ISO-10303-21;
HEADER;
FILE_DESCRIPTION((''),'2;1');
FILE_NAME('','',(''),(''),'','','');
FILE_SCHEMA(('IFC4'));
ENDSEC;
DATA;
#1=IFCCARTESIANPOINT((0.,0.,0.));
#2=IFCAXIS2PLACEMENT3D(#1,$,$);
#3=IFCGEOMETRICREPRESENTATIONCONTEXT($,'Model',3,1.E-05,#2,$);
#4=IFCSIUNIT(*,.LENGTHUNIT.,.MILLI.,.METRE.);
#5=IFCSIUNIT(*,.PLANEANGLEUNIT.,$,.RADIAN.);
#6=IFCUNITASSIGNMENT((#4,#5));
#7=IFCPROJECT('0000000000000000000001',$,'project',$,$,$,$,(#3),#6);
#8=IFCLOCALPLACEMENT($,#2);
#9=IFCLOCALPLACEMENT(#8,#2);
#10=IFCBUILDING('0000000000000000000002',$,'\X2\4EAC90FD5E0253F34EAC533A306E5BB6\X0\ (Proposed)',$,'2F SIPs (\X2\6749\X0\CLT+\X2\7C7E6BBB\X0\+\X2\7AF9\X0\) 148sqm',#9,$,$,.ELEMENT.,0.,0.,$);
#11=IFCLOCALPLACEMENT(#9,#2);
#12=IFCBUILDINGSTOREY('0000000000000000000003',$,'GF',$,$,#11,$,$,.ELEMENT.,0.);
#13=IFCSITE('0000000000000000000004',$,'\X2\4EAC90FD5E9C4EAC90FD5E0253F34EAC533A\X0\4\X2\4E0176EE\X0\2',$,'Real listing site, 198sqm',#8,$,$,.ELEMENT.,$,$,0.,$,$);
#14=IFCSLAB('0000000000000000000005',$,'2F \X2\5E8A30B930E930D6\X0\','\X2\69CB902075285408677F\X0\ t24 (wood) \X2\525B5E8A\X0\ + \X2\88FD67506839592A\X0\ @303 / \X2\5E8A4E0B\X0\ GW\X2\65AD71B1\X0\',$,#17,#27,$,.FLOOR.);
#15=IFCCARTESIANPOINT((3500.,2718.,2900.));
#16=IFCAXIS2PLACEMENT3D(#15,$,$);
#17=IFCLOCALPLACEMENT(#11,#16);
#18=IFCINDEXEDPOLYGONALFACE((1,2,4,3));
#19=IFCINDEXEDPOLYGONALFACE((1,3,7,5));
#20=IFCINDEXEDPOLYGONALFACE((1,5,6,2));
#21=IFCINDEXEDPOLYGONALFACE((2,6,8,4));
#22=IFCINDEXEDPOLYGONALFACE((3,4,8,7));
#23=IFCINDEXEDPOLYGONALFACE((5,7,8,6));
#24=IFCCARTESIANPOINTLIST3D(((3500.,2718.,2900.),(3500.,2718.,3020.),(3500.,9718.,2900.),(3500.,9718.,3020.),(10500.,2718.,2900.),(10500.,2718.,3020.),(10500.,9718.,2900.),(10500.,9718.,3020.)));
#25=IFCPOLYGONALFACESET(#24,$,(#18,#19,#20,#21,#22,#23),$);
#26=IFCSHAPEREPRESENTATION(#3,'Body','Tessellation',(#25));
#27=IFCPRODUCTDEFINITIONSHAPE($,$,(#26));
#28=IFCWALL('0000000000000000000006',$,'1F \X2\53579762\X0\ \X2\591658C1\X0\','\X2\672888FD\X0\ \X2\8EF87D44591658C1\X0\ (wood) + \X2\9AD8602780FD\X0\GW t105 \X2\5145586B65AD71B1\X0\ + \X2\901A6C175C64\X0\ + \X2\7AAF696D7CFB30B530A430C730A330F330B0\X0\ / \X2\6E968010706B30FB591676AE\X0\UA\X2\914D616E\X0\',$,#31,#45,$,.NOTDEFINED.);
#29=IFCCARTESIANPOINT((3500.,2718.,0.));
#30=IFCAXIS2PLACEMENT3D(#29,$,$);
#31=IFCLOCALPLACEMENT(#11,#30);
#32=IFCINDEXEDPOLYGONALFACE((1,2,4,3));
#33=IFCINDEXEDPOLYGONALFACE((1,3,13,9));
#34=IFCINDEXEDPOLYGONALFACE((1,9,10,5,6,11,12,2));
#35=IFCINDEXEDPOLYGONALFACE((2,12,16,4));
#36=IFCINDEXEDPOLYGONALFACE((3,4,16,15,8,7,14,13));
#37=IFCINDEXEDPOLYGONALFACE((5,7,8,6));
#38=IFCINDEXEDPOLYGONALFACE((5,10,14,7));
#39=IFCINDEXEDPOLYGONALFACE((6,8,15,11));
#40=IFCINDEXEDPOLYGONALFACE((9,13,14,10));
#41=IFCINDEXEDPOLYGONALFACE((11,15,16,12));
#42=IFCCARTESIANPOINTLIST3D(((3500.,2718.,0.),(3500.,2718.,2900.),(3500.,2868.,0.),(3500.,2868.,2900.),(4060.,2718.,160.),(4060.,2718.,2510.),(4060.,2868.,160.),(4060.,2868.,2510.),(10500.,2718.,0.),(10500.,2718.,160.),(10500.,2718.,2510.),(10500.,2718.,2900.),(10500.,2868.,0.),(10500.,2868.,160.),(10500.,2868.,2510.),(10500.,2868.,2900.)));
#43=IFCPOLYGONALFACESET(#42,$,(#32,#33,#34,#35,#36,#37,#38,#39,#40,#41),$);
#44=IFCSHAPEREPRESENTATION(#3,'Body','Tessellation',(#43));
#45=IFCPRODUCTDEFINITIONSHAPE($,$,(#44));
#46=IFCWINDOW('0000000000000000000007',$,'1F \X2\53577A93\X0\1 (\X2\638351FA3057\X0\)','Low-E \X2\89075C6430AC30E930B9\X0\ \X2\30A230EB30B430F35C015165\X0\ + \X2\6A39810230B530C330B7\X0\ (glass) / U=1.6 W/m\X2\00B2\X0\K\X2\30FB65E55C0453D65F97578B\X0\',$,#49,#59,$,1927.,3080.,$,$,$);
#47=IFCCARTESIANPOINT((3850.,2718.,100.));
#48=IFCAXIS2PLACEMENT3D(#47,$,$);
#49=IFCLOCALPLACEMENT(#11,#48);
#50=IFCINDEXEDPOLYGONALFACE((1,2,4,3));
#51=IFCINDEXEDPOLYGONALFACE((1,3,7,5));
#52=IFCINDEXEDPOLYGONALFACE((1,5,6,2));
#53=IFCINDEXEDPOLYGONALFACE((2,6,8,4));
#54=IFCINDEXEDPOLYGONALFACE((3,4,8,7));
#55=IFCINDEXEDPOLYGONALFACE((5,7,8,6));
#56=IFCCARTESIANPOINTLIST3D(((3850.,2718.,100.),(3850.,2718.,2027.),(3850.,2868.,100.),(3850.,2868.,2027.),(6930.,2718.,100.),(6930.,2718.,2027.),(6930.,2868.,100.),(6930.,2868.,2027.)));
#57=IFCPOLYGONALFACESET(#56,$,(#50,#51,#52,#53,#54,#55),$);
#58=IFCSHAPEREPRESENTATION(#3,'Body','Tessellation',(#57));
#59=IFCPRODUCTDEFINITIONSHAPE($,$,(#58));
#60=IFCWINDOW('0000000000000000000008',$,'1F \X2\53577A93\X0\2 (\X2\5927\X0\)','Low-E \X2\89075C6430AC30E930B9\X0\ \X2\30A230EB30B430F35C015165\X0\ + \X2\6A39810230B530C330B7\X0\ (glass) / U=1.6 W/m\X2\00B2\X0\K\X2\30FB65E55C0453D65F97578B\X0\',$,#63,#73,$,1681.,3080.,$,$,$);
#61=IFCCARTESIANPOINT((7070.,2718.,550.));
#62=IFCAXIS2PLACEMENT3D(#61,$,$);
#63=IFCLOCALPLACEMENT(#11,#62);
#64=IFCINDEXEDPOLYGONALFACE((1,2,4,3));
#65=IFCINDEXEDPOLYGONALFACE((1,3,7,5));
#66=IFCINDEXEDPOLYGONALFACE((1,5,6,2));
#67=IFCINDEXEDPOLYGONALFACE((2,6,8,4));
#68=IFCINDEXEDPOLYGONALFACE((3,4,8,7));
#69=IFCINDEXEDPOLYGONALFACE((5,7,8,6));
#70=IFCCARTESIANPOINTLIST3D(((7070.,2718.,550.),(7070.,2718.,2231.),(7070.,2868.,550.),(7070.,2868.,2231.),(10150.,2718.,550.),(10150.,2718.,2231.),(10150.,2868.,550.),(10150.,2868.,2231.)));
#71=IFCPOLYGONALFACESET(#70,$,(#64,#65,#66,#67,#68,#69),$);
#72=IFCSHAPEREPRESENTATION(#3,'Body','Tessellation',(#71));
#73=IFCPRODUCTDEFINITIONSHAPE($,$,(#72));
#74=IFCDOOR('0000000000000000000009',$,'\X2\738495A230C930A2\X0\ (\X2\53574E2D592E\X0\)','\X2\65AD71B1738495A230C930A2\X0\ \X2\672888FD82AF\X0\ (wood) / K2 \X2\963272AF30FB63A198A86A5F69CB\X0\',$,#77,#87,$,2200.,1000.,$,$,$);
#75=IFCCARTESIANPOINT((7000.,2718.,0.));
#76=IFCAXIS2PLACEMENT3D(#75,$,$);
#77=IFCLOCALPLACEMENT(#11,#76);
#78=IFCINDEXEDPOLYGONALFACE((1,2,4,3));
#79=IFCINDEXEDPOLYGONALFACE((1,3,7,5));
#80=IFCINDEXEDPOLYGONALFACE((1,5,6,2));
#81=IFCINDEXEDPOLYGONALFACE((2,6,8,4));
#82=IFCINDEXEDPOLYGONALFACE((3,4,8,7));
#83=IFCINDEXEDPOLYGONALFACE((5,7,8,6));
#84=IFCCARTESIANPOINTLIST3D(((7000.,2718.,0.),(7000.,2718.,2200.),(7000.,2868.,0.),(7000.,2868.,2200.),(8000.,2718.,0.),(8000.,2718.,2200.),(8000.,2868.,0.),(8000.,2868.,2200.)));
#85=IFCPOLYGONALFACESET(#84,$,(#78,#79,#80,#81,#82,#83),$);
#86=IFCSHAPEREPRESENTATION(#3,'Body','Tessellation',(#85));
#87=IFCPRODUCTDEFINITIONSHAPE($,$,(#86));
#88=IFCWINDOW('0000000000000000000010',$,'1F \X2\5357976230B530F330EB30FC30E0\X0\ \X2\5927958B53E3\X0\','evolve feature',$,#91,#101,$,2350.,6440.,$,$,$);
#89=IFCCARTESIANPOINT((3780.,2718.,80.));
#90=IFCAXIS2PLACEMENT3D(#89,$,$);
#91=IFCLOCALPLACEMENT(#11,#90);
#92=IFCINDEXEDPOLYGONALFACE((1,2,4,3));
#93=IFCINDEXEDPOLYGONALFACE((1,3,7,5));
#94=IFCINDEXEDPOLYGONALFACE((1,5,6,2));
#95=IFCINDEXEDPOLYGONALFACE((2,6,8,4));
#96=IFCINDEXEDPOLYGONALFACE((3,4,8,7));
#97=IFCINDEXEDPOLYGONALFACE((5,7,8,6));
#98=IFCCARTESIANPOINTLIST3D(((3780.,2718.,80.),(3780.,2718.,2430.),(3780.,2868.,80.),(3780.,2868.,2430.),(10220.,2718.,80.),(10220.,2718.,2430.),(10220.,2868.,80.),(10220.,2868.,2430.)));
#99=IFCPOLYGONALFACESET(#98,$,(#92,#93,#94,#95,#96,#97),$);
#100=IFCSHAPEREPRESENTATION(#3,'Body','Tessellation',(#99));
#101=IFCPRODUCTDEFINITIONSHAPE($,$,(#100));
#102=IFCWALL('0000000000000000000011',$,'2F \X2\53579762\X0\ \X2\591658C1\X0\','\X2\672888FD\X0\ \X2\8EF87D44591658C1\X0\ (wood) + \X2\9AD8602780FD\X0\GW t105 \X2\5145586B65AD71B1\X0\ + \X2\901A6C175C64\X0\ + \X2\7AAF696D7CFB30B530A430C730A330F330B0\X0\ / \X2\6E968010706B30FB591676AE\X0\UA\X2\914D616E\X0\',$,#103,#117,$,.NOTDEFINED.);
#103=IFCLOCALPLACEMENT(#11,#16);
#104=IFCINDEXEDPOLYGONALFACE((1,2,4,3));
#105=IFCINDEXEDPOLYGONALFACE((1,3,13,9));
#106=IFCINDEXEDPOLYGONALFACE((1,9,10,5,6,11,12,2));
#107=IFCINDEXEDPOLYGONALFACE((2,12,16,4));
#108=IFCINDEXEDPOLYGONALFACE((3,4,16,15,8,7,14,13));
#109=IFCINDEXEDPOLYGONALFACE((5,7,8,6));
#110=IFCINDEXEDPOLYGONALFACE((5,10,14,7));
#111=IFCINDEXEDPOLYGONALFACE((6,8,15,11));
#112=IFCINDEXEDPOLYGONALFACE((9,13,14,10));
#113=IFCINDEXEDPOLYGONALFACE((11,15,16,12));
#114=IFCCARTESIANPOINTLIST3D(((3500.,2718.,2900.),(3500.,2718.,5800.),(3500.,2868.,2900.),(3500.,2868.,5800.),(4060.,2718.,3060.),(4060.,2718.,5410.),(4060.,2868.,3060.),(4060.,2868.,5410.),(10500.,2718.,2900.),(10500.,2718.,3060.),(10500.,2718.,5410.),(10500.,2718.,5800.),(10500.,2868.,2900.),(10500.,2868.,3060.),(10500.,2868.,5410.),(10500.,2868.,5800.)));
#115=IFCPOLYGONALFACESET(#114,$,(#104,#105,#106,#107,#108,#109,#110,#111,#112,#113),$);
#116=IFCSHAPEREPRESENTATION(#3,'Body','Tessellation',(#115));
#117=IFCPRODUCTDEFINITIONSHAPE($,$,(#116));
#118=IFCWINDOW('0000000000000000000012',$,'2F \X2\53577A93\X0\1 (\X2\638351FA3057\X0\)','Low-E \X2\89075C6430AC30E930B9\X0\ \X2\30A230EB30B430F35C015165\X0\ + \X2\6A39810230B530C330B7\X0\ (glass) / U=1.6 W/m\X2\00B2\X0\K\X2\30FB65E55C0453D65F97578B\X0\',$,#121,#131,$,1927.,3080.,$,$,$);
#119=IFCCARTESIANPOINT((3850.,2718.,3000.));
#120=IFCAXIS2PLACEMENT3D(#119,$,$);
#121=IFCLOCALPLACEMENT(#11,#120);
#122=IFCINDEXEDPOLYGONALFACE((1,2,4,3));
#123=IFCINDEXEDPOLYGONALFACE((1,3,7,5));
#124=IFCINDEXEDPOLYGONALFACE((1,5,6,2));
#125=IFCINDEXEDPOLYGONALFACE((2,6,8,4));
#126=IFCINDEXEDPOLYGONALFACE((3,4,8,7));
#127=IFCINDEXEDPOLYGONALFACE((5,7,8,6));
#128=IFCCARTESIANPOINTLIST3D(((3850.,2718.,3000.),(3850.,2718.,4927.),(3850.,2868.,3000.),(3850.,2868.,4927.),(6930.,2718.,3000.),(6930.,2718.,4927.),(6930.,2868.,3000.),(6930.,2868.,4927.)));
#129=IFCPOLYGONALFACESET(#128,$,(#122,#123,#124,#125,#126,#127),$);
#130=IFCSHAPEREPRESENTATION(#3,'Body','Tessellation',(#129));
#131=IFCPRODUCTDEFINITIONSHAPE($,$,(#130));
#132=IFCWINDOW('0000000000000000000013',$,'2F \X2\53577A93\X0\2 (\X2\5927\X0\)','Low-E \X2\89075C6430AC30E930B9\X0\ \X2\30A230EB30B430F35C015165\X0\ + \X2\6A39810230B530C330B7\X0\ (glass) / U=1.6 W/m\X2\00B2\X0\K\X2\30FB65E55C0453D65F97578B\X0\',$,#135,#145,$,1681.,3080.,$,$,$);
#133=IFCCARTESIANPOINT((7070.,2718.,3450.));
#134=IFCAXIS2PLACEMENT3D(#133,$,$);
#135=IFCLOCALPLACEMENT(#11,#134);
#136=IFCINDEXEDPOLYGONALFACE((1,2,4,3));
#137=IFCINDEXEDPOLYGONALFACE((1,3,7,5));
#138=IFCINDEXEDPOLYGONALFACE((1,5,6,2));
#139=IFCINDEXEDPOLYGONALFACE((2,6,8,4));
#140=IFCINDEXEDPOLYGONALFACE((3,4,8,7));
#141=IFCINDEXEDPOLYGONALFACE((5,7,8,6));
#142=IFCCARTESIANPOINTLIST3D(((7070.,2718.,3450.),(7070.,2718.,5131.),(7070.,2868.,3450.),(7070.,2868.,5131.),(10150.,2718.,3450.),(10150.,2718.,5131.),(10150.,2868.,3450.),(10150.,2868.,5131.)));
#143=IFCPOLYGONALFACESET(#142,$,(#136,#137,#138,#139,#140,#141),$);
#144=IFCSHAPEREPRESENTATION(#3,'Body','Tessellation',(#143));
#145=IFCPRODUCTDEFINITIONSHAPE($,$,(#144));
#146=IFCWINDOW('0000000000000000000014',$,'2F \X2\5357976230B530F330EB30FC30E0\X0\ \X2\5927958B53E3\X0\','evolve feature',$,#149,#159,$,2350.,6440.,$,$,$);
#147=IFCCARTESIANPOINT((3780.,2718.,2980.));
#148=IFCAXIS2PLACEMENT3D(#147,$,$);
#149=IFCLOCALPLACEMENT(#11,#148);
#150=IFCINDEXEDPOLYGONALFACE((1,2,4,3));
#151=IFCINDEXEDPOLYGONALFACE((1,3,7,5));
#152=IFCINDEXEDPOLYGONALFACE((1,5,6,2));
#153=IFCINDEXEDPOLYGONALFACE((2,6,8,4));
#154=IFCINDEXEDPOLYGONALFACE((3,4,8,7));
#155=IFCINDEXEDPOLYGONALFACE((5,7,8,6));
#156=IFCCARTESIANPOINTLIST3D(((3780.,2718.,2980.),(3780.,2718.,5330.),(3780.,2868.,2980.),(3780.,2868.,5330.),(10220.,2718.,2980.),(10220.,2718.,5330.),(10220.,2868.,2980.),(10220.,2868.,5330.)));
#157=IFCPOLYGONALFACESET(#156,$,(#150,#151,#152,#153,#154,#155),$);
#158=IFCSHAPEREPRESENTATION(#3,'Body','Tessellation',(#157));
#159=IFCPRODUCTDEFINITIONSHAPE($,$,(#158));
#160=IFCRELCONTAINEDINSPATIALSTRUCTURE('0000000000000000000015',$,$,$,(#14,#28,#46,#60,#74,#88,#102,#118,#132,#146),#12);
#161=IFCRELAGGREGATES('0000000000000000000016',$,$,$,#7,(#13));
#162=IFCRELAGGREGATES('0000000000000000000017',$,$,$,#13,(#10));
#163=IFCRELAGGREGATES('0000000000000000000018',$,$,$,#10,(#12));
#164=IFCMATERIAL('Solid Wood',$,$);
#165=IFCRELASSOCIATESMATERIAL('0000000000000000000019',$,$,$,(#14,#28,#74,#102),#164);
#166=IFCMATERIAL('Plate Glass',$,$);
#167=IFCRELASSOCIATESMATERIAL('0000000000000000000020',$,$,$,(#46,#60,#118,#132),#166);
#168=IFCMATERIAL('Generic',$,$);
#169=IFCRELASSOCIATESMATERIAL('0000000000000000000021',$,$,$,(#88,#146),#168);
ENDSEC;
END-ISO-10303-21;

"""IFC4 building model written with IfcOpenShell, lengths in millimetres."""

from ifc_helpers import new_model, si_unit, frame, frame_2d, origin, place, context, project, spatial, rectangle, extrude, material, element, fill, save


model = new_model("IFC4")

# Units and contexts
model_context = context("Model", 3, precision=1e-05, world=origin())
ifc_project = project(units=[si_unit("LENGTHUNIT", "METRE", prefix="MILLI"), si_unit("PLANEANGLEUNIT", "RADIAN")], contexts=[model_context])

# Site, building, storey
site_placement = place(None, origin())
site = spatial("IfcSite", under=ifc_project, at=site_placement, Name="京都府京都市右京区4丁目2", ObjectType="Real listing site, 198sqm", CompositionType="ELEMENT", RefElevation=0.0)
building_placement = place(site_placement, origin())
building = spatial("IfcBuilding", under=site, at=building_placement, Name="京都市右京区の家 (Proposed)", ObjectType="2F SIPs (杉CLT+籾殻+竹) 148sqm", CompositionType="ELEMENT", ElevationOfRefHeight=0.0, ElevationOfTerrain=0.0)
storey_placement = place(building_placement, origin())
storey = spatial("IfcBuildingStorey", under=building, at=storey_placement, Name="GF", CompositionType="ELEMENT", Elevation=0.0)

# Slab
ifc_material_1 = material(Name="Solid Wood")
slab_1_placement = place(storey_placement, frame((3500.0, 2718.0, 2900.0)))
element("IfcSlab", 1, at=slab_1_placement, inside=storey, material=ifc_material_1, Name="2F 床スラブ", Description="構造用合板 t24 (wood) 剛床 + 製材根太 @303 / 床下 GW断熱", PredefinedType="FLOOR", context=model_context, shape_type="SweptSolid", body=[
    extrude(rectangle(XDim=7000.0, YDim=7000.0, at=frame_2d((3500.0, 3500.0))), frame((3500.0, 2718.0, 2900.0)), (0.0, 0.0, 1.0), 120.0),
])
ifc_material_2 = material(Name="Generic")

# Wall, openings, windows, door
wall_1_placement = place(storey_placement, frame((3500.0, 2718.0, 0.0)))
wall_1 = element("IfcWall", 2, at=wall_1_placement, inside=storey, material=ifc_material_1, Name="1F 南面 外壁", Description="木製 軸組外壁 (wood) + 高性能GW t105 充填断熱 + 通気層 + 窯業系サイディング / 準耐火・外皮UA配慮", PredefinedType="NOTDEFINED", context=model_context, shape_type="SweptSolid", body=[
    extrude(rectangle(XDim=7000.0, YDim=150.0, at=frame_2d((3500.0, 75.0))), frame((3500.0, 2718.0, 0.0)), (0.0, 0.0, 1.0), 2900.0),
])
opening_1_placement = place(storey_placement, frame((3850.0, 2718.0, 100.0)))
opening_1 = element("IfcOpeningElement", 3, at=opening_1_placement, cuts=wall_1, PredefinedType="NOTDEFINED", context=model_context, shape_type="SweptSolid", body=[
    extrude(rectangle(XDim=3080.0, YDim=150.0, at=frame_2d((1540.0, 75.0))), frame((3850.0, 2718.0, 100.0)), (0.0, 0.0, 1.0), 1927.0),
])
opening_2_placement = place(storey_placement, frame((7070.0, 2718.0, 550.0)))
opening_2 = element("IfcOpeningElement", 4, at=opening_2_placement, cuts=wall_1, PredefinedType="NOTDEFINED", context=model_context, shape_type="SweptSolid", body=[
    extrude(rectangle(XDim=3080.0, YDim=150.0, at=frame_2d((1540.0, 75.0))), frame((7070.0, 2718.0, 550.0)), (0.0, 0.0, 1.0), 1681.0),
])
opening_3_placement = place(storey_placement, frame((7000.0, 2718.0, 0.0)))
opening_3 = element("IfcOpeningElement", 5, at=opening_3_placement, cuts=wall_1, PredefinedType="NOTDEFINED", context=model_context, shape_type="SweptSolid", body=[
    extrude(rectangle(XDim=1000.0, YDim=150.0, at=frame_2d((500.0, 75.0))), frame((7000.0, 2718.0, 0.0)), (0.0, 0.0, 1.0), 2200.0),
])
opening_4_placement = place(storey_placement, frame((3780.0, 2718.0, 80.0)))
opening_4 = element("IfcOpeningElement", 6, at=opening_4_placement, cuts=wall_1, PredefinedType="NOTDEFINED", context=model_context, shape_type="SweptSolid", body=[
    extrude(rectangle(XDim=6440.0, YDim=150.0, at=frame_2d((3220.0, 75.0))), frame((3780.0, 2718.0, 80.0)), (0.0, 0.0, 1.0), 2350.0),
])
ifc_material_3 = material(Name="Plate Glass")
window_1_placement = place(storey_placement, frame((3850.0, 2718.0, 100.0)))
window_1 = element("IfcWindow", 7, at=window_1_placement, inside=storey, material=ifc_material_3, Name="1F 南窓1 (掃出し)", Description="Low-E 複層ガラス アルゴン封入 + 樹脂サッシ (glass) / U=1.6 W/m²K・日射取得型", OverallHeight=1927.0, OverallWidth=3080.0, context=model_context, shape_type="SweptSolid", body=[
    extrude(rectangle(XDim=3080.0, YDim=150.0, at=frame_2d((1540.0, 75.0))), frame((3850.0, 2718.0, 100.0)), (0.0, 0.0, 1.0), 1927.0),
])
fill(opening_1, window_1)
window_2_placement = place(storey_placement, frame((7070.0, 2718.0, 550.0)))
window_2 = element("IfcWindow", 8, at=window_2_placement, inside=storey, material=ifc_material_3, Name="1F 南窓2 (大)", Description="Low-E 複層ガラス アルゴン封入 + 樹脂サッシ (glass) / U=1.6 W/m²K・日射取得型", OverallHeight=1681.0, OverallWidth=3080.0, context=model_context, shape_type="SweptSolid", body=[
    extrude(rectangle(XDim=3080.0, YDim=150.0, at=frame_2d((1540.0, 75.0))), frame((7070.0, 2718.0, 550.0)), (0.0, 0.0, 1.0), 1681.0),
])
fill(opening_2, window_2)
door_placement = place(storey_placement, frame((7000.0, 2718.0, 0.0)))
door = element("IfcDoor", 9, at=door_placement, inside=storey, material=ifc_material_1, Name="玄関ドア (南中央)", Description="断熱玄関ドア 木製芯 (wood) / K2 防犯・採風機構", OverallHeight=2200.0, OverallWidth=1000.0, context=model_context, shape_type="SweptSolid", body=[
    extrude(rectangle(XDim=1000.0, YDim=150.0, at=frame_2d((500.0, 75.0))), frame((7000.0, 2718.0, 0.0)), (0.0, 0.0, 1.0), 2200.0),
])
fill(opening_3, door)
window_3_placement = place(storey_placement, frame((3780.0, 2718.0, 80.0)))
window_3 = element("IfcWindow", 10, at=window_3_placement, inside=storey, material=ifc_material_2, Name="1F 南面サンルーム 大開口", Description="evolve feature", OverallHeight=2350.0, OverallWidth=6440.0, context=model_context, shape_type="SweptSolid", body=[
    extrude(rectangle(XDim=6440.0, YDim=150.0, at=frame_2d((3220.0, 75.0))), frame((3780.0, 2718.0, 80.0)), (0.0, 0.0, 1.0), 2350.0),
])
fill(opening_4, window_3)

# Wall, openings, windows
wall_2_placement = place(storey_placement, frame((3500.0, 2718.0, 2900.0)))
wall_2 = element("IfcWall", 11, at=wall_2_placement, inside=storey, material=ifc_material_1, Name="2F 南面 外壁", Description="木製 軸組外壁 (wood) + 高性能GW t105 充填断熱 + 通気層 + 窯業系サイディング / 準耐火・外皮UA配慮", PredefinedType="NOTDEFINED", context=model_context, shape_type="SweptSolid", body=[
    extrude(rectangle(XDim=7000.0, YDim=150.0, at=frame_2d((3500.0, 75.0))), frame((3500.0, 2718.0, 2900.0)), (0.0, 0.0, 1.0), 2900.0),
])
opening_5_placement = place(storey_placement, frame((3850.0, 2718.0, 3000.0)))
opening_5 = element("IfcOpeningElement", 12, at=opening_5_placement, cuts=wall_2, PredefinedType="NOTDEFINED", context=model_context, shape_type="SweptSolid", body=[
    extrude(rectangle(XDim=3080.0, YDim=150.0, at=frame_2d((1540.0, 75.0))), frame((3850.0, 2718.0, 3000.0)), (0.0, 0.0, 1.0), 1927.0),
])
opening_6_placement = place(storey_placement, frame((7070.0, 2718.0, 3450.0)))
opening_6 = element("IfcOpeningElement", 13, at=opening_6_placement, cuts=wall_2, PredefinedType="NOTDEFINED", context=model_context, shape_type="SweptSolid", body=[
    extrude(rectangle(XDim=3080.0, YDim=150.0, at=frame_2d((1540.0, 75.0))), frame((7070.0, 2718.0, 3450.0)), (0.0, 0.0, 1.0), 1681.0),
])
opening_7_placement = place(storey_placement, frame((3780.0, 2718.0, 2980.0)))
opening_7 = element("IfcOpeningElement", 14, at=opening_7_placement, cuts=wall_2, PredefinedType="NOTDEFINED", context=model_context, shape_type="SweptSolid", body=[
    extrude(rectangle(XDim=6440.0, YDim=150.0, at=frame_2d((3220.0, 75.0))), frame((3780.0, 2718.0, 2980.0)), (0.0, 0.0, 1.0), 2350.0),
])
window_4_placement = place(storey_placement, frame((3850.0, 2718.0, 3000.0)))
window_4 = element("IfcWindow", 15, at=window_4_placement, inside=storey, material=ifc_material_3, Name="2F 南窓1 (掃出し)", Description="Low-E 複層ガラス アルゴン封入 + 樹脂サッシ (glass) / U=1.6 W/m²K・日射取得型", OverallHeight=1927.0, OverallWidth=3080.0, context=model_context, shape_type="SweptSolid", body=[
    extrude(rectangle(XDim=3080.0, YDim=150.0, at=frame_2d((1540.0, 75.0))), frame((3850.0, 2718.0, 3000.0)), (0.0, 0.0, 1.0), 1927.0),
])
fill(opening_5, window_4)
window_5_placement = place(storey_placement, frame((7070.0, 2718.0, 3450.0)))
window_5 = element("IfcWindow", 16, at=window_5_placement, inside=storey, material=ifc_material_3, Name="2F 南窓2 (大)", Description="Low-E 複層ガラス アルゴン封入 + 樹脂サッシ (glass) / U=1.6 W/m²K・日射取得型", OverallHeight=1681.0, OverallWidth=3080.0, context=model_context, shape_type="SweptSolid", body=[
    extrude(rectangle(XDim=3080.0, YDim=150.0, at=frame_2d((1540.0, 75.0))), frame((7070.0, 2718.0, 3450.0)), (0.0, 0.0, 1.0), 1681.0),
])
fill(opening_6, window_5)
window_6_placement = place(storey_placement, frame((3780.0, 2718.0, 2980.0)))
window_6 = element("IfcWindow", 17, at=window_6_placement, inside=storey, material=ifc_material_2, Name="2F 南面サンルーム 大開口", Description="evolve feature", OverallHeight=2350.0, OverallWidth=6440.0, context=model_context, shape_type="SweptSolid", body=[
    extrude(rectangle(XDim=6440.0, YDim=150.0, at=frame_2d((3220.0, 75.0))), frame((3780.0, 2718.0, 2980.0)), (0.0, 0.0, 1.0), 2350.0),
])
fill(opening_7, window_6)

save(model, "model.ifc")
